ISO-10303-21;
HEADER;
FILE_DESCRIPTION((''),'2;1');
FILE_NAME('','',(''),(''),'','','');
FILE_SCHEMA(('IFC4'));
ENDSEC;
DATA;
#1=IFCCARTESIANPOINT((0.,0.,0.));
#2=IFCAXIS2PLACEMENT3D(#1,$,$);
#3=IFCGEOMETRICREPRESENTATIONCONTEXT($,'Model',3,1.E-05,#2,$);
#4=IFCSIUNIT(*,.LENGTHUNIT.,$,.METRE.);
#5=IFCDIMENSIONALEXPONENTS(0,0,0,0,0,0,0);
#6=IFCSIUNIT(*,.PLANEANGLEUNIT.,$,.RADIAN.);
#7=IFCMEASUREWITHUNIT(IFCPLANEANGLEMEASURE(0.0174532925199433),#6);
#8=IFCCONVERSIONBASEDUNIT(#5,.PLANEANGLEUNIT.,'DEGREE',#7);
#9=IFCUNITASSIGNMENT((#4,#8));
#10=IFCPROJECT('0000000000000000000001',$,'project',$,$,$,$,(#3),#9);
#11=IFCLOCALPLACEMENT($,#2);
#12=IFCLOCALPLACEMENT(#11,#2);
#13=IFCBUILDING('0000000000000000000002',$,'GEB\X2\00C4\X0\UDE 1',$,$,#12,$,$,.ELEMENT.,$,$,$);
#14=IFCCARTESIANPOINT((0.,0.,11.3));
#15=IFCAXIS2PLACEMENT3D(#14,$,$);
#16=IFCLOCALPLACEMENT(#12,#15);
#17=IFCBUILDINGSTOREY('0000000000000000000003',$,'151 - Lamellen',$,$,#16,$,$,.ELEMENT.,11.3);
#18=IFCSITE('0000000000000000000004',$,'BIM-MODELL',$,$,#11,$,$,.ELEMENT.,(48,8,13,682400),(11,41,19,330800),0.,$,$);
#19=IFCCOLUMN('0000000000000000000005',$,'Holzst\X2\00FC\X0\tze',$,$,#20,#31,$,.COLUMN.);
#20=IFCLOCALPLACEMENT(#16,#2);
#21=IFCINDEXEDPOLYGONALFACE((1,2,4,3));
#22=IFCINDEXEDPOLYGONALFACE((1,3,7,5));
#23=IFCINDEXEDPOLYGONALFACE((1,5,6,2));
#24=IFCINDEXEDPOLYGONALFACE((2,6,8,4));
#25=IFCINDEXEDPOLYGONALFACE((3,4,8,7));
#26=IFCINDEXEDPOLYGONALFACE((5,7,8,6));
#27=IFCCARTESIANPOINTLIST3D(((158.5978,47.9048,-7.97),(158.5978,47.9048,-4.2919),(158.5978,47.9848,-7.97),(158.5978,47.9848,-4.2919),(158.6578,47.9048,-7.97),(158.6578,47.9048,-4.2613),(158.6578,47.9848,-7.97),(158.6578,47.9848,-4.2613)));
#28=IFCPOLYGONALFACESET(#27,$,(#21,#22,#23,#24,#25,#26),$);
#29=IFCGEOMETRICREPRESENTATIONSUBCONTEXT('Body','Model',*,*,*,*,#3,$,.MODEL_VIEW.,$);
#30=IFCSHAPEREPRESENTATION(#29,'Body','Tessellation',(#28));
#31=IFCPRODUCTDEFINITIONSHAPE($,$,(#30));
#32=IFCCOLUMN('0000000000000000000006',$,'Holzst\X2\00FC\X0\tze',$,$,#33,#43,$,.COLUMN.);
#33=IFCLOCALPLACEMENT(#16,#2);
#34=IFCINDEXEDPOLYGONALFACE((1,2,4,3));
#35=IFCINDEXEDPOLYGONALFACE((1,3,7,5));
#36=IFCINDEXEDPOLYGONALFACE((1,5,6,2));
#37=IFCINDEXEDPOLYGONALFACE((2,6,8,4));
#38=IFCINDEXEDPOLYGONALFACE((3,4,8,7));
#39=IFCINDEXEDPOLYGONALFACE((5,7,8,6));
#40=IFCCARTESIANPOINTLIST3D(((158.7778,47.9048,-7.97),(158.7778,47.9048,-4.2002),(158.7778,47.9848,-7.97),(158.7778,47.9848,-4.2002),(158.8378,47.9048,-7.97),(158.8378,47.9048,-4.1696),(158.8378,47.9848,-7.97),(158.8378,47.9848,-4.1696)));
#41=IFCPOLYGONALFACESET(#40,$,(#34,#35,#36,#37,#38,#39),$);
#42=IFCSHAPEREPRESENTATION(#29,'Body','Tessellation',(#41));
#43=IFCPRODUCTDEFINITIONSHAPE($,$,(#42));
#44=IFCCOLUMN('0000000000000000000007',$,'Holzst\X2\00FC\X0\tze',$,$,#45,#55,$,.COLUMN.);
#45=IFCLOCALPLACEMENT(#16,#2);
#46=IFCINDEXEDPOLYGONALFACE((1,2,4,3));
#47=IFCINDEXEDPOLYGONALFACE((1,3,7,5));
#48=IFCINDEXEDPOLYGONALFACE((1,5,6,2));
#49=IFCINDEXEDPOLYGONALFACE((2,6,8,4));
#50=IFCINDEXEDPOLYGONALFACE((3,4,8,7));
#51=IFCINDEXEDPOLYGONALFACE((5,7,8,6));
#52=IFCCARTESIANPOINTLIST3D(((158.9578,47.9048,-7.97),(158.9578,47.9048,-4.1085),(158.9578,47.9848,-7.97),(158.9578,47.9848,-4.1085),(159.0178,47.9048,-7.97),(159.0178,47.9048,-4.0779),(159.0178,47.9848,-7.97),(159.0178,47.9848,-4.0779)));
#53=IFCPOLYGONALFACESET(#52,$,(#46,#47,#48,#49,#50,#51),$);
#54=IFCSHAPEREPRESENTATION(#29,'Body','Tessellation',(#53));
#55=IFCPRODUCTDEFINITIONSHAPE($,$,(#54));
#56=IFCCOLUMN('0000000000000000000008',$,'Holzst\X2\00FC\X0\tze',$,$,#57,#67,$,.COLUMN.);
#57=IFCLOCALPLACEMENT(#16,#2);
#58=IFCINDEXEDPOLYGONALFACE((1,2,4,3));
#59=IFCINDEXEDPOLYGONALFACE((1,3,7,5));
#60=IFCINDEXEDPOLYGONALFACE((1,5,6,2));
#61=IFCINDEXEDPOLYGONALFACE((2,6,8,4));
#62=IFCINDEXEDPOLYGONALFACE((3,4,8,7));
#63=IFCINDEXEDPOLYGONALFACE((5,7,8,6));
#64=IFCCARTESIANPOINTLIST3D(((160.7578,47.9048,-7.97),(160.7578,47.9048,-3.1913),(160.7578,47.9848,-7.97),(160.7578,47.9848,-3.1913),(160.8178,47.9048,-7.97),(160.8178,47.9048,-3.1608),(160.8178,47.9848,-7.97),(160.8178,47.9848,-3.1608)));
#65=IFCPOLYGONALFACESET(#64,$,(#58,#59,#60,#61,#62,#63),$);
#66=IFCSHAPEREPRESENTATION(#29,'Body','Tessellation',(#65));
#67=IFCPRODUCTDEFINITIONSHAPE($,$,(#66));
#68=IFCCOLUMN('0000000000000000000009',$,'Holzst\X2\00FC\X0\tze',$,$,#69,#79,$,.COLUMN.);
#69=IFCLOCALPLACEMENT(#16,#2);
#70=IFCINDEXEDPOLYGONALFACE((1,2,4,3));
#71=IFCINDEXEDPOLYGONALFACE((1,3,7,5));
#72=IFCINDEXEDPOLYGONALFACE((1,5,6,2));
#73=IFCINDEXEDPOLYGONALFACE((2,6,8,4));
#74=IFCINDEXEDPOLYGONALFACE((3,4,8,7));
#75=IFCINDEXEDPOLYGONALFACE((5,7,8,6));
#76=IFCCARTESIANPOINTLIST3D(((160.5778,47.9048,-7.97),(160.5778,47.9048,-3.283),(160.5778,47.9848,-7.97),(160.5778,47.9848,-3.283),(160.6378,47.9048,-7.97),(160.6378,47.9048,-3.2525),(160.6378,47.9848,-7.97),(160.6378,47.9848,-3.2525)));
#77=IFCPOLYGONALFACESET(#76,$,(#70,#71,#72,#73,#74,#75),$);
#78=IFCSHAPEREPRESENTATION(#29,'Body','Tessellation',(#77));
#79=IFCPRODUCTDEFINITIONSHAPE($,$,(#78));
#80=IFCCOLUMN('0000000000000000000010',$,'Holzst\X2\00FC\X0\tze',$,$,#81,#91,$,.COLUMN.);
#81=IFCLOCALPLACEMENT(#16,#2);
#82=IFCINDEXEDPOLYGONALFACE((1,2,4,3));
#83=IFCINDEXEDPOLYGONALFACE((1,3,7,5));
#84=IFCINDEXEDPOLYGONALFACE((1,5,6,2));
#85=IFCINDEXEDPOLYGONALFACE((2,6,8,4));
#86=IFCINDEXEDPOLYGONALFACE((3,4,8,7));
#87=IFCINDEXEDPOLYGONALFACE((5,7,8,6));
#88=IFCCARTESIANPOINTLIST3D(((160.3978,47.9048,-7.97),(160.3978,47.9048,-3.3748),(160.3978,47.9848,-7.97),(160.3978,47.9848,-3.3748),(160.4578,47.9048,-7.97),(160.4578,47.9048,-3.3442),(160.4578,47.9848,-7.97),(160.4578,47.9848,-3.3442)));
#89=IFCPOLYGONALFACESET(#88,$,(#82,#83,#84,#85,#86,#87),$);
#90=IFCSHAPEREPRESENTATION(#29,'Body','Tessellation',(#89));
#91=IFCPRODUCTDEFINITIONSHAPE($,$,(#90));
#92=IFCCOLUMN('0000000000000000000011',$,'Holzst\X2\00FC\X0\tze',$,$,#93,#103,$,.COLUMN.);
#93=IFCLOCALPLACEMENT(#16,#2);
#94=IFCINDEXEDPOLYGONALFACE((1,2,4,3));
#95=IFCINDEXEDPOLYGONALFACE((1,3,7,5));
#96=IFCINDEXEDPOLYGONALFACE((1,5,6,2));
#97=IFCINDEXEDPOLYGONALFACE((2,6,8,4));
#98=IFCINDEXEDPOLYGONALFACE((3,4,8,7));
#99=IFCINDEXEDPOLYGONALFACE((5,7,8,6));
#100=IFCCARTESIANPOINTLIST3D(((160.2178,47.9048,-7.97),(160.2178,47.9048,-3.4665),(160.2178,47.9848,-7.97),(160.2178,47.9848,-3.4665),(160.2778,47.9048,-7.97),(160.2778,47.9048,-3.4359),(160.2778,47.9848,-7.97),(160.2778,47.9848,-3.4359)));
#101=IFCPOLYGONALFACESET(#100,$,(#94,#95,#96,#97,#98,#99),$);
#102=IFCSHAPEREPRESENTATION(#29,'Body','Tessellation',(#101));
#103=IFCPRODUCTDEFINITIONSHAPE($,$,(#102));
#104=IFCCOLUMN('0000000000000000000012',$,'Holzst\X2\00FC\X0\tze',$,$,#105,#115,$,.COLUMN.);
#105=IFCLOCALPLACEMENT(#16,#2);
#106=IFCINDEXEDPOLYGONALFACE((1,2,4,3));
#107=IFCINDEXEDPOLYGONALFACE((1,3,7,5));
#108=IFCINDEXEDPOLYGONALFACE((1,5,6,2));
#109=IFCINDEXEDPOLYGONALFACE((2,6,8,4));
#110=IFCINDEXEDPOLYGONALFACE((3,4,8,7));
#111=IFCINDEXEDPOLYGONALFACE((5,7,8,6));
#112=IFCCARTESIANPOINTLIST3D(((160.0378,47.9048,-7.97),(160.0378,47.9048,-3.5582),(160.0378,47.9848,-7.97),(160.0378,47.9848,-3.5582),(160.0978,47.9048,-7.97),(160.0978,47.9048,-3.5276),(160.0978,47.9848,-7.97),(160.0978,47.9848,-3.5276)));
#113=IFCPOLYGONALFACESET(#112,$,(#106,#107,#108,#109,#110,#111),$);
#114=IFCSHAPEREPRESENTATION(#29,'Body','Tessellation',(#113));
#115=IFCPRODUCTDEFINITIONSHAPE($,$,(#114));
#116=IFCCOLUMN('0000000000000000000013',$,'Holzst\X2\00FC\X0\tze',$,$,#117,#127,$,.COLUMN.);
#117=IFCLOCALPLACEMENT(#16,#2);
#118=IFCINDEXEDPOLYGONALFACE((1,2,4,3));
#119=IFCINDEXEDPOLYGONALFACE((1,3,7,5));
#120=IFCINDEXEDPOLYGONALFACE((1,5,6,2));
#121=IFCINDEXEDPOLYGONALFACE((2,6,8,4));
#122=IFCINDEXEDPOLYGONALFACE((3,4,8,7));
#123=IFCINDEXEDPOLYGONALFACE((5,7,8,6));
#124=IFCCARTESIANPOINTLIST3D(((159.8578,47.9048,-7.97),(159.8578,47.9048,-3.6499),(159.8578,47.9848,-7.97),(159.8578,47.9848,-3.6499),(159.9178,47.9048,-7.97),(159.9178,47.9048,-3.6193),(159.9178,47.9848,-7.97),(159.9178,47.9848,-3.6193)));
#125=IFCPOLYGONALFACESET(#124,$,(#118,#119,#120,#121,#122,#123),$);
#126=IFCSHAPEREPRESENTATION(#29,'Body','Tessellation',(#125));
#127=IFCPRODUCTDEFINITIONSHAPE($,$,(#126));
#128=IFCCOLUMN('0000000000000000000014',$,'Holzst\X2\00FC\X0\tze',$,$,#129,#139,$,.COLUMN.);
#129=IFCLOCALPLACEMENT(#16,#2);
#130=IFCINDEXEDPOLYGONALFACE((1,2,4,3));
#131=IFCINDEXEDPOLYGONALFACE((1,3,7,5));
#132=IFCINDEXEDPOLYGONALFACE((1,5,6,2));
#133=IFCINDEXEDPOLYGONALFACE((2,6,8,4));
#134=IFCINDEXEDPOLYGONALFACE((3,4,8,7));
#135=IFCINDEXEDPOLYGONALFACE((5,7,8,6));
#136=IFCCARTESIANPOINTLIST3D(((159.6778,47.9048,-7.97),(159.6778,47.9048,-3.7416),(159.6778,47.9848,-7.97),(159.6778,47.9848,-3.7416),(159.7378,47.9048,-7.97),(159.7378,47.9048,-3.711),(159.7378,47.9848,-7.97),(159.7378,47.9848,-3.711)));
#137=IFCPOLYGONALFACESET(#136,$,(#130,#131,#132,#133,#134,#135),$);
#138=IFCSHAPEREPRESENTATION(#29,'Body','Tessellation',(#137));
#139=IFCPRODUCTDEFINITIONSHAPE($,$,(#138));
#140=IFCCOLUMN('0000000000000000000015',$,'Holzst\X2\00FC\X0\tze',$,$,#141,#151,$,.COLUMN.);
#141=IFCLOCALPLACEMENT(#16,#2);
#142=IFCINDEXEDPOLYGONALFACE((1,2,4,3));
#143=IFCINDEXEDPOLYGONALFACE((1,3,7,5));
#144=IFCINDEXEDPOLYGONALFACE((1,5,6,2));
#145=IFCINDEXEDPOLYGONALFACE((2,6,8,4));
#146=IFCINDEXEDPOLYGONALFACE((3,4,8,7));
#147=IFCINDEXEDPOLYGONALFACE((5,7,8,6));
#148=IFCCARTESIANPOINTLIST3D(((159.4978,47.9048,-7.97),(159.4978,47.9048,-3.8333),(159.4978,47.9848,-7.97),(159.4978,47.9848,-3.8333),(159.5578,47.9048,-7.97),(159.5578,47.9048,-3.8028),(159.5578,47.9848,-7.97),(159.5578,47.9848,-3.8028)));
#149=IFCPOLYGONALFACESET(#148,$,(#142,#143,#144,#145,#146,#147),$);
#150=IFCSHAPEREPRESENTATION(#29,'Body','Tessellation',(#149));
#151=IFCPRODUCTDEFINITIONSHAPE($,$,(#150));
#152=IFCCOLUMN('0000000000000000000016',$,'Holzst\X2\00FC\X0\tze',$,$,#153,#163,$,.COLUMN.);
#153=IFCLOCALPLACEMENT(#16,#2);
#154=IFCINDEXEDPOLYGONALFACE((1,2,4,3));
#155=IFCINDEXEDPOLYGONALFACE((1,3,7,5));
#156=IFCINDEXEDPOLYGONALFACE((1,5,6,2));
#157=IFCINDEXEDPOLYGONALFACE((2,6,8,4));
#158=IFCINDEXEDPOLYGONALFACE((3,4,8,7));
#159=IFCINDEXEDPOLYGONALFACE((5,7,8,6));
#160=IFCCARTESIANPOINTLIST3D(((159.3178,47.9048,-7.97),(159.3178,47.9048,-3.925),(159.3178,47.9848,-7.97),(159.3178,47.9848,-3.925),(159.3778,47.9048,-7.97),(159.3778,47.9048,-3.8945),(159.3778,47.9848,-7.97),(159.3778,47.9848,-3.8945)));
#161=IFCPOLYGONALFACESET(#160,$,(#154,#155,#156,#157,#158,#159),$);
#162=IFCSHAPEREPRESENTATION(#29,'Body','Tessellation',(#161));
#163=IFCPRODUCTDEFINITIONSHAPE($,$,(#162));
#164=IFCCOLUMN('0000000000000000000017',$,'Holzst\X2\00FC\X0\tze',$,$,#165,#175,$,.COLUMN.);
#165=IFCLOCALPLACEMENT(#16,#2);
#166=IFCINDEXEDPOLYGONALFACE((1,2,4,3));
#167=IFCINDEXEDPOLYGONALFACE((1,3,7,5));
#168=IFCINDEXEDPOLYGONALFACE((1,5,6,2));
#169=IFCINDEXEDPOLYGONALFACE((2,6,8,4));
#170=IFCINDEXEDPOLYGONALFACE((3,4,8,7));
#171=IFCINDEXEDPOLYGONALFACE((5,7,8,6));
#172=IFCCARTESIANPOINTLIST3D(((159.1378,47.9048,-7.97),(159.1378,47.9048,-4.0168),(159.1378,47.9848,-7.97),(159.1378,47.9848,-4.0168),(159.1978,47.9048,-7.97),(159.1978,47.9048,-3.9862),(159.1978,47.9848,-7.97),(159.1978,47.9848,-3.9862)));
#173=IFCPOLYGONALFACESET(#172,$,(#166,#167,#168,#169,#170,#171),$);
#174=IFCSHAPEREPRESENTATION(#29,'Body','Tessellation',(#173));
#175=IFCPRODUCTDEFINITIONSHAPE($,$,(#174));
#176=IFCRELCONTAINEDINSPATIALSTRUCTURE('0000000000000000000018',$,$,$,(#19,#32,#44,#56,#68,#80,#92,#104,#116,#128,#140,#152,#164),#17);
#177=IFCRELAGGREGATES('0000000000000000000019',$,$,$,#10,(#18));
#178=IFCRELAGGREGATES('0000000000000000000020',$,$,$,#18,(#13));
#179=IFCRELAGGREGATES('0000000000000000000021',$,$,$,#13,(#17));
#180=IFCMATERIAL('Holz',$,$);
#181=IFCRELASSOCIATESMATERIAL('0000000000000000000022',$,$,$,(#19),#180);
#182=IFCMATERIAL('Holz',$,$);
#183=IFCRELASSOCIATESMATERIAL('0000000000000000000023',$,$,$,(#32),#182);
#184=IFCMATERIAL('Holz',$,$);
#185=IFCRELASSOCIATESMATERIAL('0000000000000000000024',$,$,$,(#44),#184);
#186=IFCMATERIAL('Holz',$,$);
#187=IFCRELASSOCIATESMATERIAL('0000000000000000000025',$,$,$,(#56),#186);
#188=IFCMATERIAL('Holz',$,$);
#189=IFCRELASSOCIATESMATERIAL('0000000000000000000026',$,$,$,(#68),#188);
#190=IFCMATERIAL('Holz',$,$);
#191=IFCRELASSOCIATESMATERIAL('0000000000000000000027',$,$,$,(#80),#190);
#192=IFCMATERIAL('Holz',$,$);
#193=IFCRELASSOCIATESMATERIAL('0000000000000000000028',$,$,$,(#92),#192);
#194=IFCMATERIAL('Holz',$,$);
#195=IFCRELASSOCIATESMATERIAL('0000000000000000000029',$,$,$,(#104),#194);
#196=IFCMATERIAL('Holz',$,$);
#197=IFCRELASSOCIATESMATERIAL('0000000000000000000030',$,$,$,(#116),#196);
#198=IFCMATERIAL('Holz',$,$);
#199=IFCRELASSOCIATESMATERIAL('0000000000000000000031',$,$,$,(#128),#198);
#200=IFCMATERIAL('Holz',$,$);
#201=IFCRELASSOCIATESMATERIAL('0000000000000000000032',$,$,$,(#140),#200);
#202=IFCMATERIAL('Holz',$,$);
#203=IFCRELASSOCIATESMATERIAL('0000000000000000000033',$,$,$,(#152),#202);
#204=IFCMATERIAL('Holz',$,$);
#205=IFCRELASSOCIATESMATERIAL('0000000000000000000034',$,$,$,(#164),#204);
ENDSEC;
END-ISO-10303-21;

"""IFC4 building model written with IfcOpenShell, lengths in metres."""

from ifc_helpers import new_model, entity, si_unit, converted_unit, frame, frame_2d, origin, origin_with_axes, place, context, subcontext, project, spatial, rectangle, extrude, clip, halfspace, material, element, save


model = new_model("IFC4")

# Units and contexts
model_context = context("Model", 3, precision=1e-05, world=origin())
body_context = subcontext(model_context, "Body", "Model", "MODEL_VIEW")
ifc_project = project(units=[si_unit("LENGTHUNIT", "METRE"), converted_unit("PLANEANGLEUNIT", "DEGREE", entity("IfcPlaneAngleMeasure", 0.0174532925199433), si_unit("PLANEANGLEUNIT", "RADIAN"), dimensions=[0, 0, 0, 0, 0, 0, 0])], contexts=[model_context])

# Site, building, storey
site_placement = place(None, origin())
site = spatial("IfcSite", under=ifc_project, at=site_placement, Name="BIM-MODELL", CompositionType="ELEMENT", RefLatitude=(48, 8, 13, 682400), RefLongitude=(11, 41, 19, 330800), RefElevation=0.0)
building_placement = place(site_placement, origin())
building = spatial("IfcBuilding", under=site, at=building_placement, Name="GEBÄUDE 1", CompositionType="ELEMENT")
storey_placement = place(building_placement, frame((0.0, 0.0, 11.3)))
storey = spatial("IfcBuildingStorey", under=building, at=storey_placement, Name="151 - Lamellen", CompositionType="ELEMENT", Elevation=11.3)

# Columns
ifc_material_1 = material(Name="Holz")
column_1_placement = place(storey_placement, frame((158.5978, 47.9048, -7.97)))
element("IfcColumn", 1, at=column_1_placement, inside=storey, material=ifc_material_1, Name="Holzstütze", PredefinedType="COLUMN", context=body_context, shape_type="Clipping", body=[
    clip(extrude(rectangle(XDim=0.06, YDim=0.08, at=frame_2d((0.03, 0.04), x_axis=(1.0, 0.0))), origin_with_axes(), (0.0, 0.0, 1.0), 3.7087), halfspace(frame((0.03, 0.04, 3.6934), z_axis=(0.45399, 0.0, -0.891007), x_axis=(0.0, 1.0, 0.0)), True)),
])
ifc_material_2 = material(Name="Holz")
column_2_placement = place(storey_placement, frame((158.7778, 47.9048, -7.97)))
element("IfcColumn", 2, at=column_2_placement, inside=storey, material=ifc_material_2, Name="Holzstütze", PredefinedType="COLUMN", context=body_context, shape_type="Clipping", body=[
    clip(extrude(rectangle(XDim=0.06, YDim=0.08, at=frame_2d((0.03, 0.04), x_axis=(1.0, 0.0))), origin_with_axes(), (0.0, 0.0, 1.0), 3.8004), halfspace(frame((0.03, 0.04, 3.7851), z_axis=(0.45399, 0.0, -0.891007), x_axis=(0.0, 1.0, 0.0)), True)),
])
ifc_material_3 = material(Name="Holz")
column_3_placement = place(storey_placement, frame((158.9578, 47.9048, -7.97)))
element("IfcColumn", 3, at=column_3_placement, inside=storey, material=ifc_material_3, Name="Holzstütze", PredefinedType="COLUMN", context=body_context, shape_type="Clipping", body=[
    clip(extrude(rectangle(XDim=0.06, YDim=0.08, at=frame_2d((0.03, 0.04), x_axis=(1.0, 0.0))), origin_with_axes(), (0.0, 0.0, 1.0), 3.8921), halfspace(frame((0.03, 0.04, 3.8768), z_axis=(0.45399, 0.0, -0.891007), x_axis=(0.0, 1.0, 0.0)), True)),
])
ifc_material_4 = material(Name="Holz")
column_4_placement = place(storey_placement, frame((160.7578, 47.9048, -7.97)))
element("IfcColumn", 4, at=column_4_placement, inside=storey, material=ifc_material_4, Name="Holzstütze", PredefinedType="COLUMN", context=body_context, shape_type="Clipping", body=[
    clip(extrude(rectangle(XDim=0.06, YDim=0.08, at=frame_2d((0.03, 0.04), x_axis=(1.0, 0.0))), origin_with_axes(), (0.0, 0.0, 1.0), 4.8092), halfspace(frame((0.03, 0.04, 4.794), z_axis=(0.45399, 0.0, -0.891007), x_axis=(0.0, 1.0, 0.0)), True)),
])
ifc_material_5 = material(Name="Holz")
column_5_placement = place(storey_placement, frame((160.5778, 47.9048, -7.97)))
element("IfcColumn", 5, at=column_5_placement, inside=storey, material=ifc_material_5, Name="Holzstütze", PredefinedType="COLUMN", context=body_context, shape_type="Clipping", body=[
    clip(extrude(rectangle(XDim=0.06, YDim=0.08, at=frame_2d((0.03, 0.04), x_axis=(1.0, 0.0))), origin_with_axes(), (0.0, 0.0, 1.0), 4.7175), halfspace(frame((0.03, 0.04, 4.7022), z_axis=(0.45399, 0.0, -0.891007), x_axis=(0.0, 1.0, 0.0)), True)),
])
ifc_material_6 = material(Name="Holz")
column_6_placement = place(storey_placement, frame((160.3978, 47.9048, -7.97)))
element("IfcColumn", 6, at=column_6_placement, inside=storey, material=ifc_material_6, Name="Holzstütze", PredefinedType="COLUMN", context=body_context, shape_type="Clipping", body=[
    clip(extrude(rectangle(XDim=0.06, YDim=0.08, at=frame_2d((0.03, 0.04), x_axis=(1.0, 0.0))), origin_with_axes(), (0.0, 0.0, 1.0), 4.6258), halfspace(frame((0.03, 0.04, 4.6105), z_axis=(0.45399, 0.0, -0.891007), x_axis=(0.0, 1.0, 0.0)), True)),
])
ifc_material_7 = material(Name="Holz")
column_7_placement = place(storey_placement, frame((160.2178, 47.9048, -7.97)))
element("IfcColumn", 7, at=column_7_placement, inside=storey, material=ifc_material_7, Name="Holzstütze", PredefinedType="COLUMN", context=body_context, shape_type="Clipping", body=[
    clip(extrude(rectangle(XDim=0.06, YDim=0.08, at=frame_2d((0.03, 0.04), x_axis=(1.0, 0.0))), origin_with_axes(), (0.0, 0.0, 1.0), 4.5341), halfspace(frame((0.03, 0.04, 4.5188), z_axis=(0.45399, 0.0, -0.891007), x_axis=(0.0, 1.0, 0.0)), True)),
])
ifc_material_8 = material(Name="Holz")
column_8_placement = place(storey_placement, frame((160.0378, 47.9048, -7.97)))
element("IfcColumn", 8, at=column_8_placement, inside=storey, material=ifc_material_8, Name="Holzstütze", PredefinedType="COLUMN", context=body_context, shape_type="Clipping", body=[
    clip(extrude(rectangle(XDim=0.06, YDim=0.08, at=frame_2d((0.03, 0.04), x_axis=(1.0, 0.0))), origin_with_axes(), (0.0, 0.0, 1.0), 4.4424), halfspace(frame((0.03, 0.04, 4.4271), z_axis=(0.45399, 0.0, -0.891007), x_axis=(0.0, 1.0, 0.0)), True)),
])
ifc_material_9 = material(Name="Holz")
column_9_placement = place(storey_placement, frame((159.8578, 47.9048, -7.97)))
element("IfcColumn", 9, at=column_9_placement, inside=storey, material=ifc_material_9, Name="Holzstütze", PredefinedType="COLUMN", context=body_context, shape_type="Clipping", body=[
    clip(extrude(rectangle(XDim=0.06, YDim=0.08, at=frame_2d((0.03, 0.04), x_axis=(1.0, 0.0))), origin_with_axes(), (0.0, 0.0, 1.0), 4.3507), halfspace(frame((0.03, 0.04, 4.3354), z_axis=(0.45399, 0.0, -0.891007), x_axis=(0.0, 1.0, 0.0)), True)),
])
ifc_material_10 = material(Name="Holz")
column_10_placement = place(storey_placement, frame((159.6778, 47.9048, -7.97)))
element("IfcColumn", 10, at=column_10_placement, inside=storey, material=ifc_material_10, Name="Holzstütze", PredefinedType="COLUMN", context=body_context, shape_type="Clipping", body=[
    clip(extrude(rectangle(XDim=0.06, YDim=0.08, at=frame_2d((0.03, 0.04), x_axis=(1.0, 0.0))), origin_with_axes(), (0.0, 0.0, 1.0), 4.259), halfspace(frame((0.03, 0.04, 4.2437), z_axis=(0.45399, 0.0, -0.891007), x_axis=(0.0, 1.0, 0.0)), True)),
])
ifc_material_11 = material(Name="Holz")
column_11_placement = place(storey_placement, frame((159.4978, 47.9048, -7.97)))
element("IfcColumn", 11, at=column_11_placement, inside=storey, material=ifc_material_11, Name="Holzstütze", PredefinedType="COLUMN", context=body_context, shape_type="Clipping", body=[
    clip(extrude(rectangle(XDim=0.06, YDim=0.08, at=frame_2d((0.03, 0.04), x_axis=(1.0, 0.0))), origin_with_axes(), (0.0, 0.0, 1.0), 4.1672), halfspace(frame((0.03, 0.04, 4.152), z_axis=(0.45399, 0.0, -0.891007), x_axis=(0.0, 1.0, 0.0)), True)),
])
ifc_material_12 = material(Name="Holz")
column_12_placement = place(storey_placement, frame((159.3178, 47.9048, -7.97)))
element("IfcColumn", 12, at=column_12_placement, inside=storey, material=ifc_material_12, Name="Holzstütze", PredefinedType="COLUMN", context=body_context, shape_type="Clipping", body=[
    clip(extrude(rectangle(XDim=0.06, YDim=0.08, at=frame_2d((0.03, 0.04), x_axis=(1.0, 0.0))), origin_with_axes(), (0.0, 0.0, 1.0), 4.0755), halfspace(frame((0.03, 0.04, 4.0602), z_axis=(0.45399, 0.0, -0.891007), x_axis=(0.0, 1.0, 0.0)), True)),
])
ifc_material_13 = material(Name="Holz")
column_13_placement = place(storey_placement, frame((159.1378, 47.9048, -7.97)))
element("IfcColumn", 13, at=column_13_placement, inside=storey, material=ifc_material_13, Name="Holzstütze", PredefinedType="COLUMN", context=body_context, shape_type="Clipping", body=[
    clip(extrude(rectangle(XDim=0.06, YDim=0.08, at=frame_2d((0.03, 0.04), x_axis=(1.0, 0.0))), origin_with_axes(), (0.0, 0.0, 1.0), 3.9838), halfspace(frame((0.03, 0.04, 3.9685), z_axis=(0.45399, 0.0, -0.891007), x_axis=(0.0, 1.0, 0.0)), True)),
])

save(model, "model.ifc")
